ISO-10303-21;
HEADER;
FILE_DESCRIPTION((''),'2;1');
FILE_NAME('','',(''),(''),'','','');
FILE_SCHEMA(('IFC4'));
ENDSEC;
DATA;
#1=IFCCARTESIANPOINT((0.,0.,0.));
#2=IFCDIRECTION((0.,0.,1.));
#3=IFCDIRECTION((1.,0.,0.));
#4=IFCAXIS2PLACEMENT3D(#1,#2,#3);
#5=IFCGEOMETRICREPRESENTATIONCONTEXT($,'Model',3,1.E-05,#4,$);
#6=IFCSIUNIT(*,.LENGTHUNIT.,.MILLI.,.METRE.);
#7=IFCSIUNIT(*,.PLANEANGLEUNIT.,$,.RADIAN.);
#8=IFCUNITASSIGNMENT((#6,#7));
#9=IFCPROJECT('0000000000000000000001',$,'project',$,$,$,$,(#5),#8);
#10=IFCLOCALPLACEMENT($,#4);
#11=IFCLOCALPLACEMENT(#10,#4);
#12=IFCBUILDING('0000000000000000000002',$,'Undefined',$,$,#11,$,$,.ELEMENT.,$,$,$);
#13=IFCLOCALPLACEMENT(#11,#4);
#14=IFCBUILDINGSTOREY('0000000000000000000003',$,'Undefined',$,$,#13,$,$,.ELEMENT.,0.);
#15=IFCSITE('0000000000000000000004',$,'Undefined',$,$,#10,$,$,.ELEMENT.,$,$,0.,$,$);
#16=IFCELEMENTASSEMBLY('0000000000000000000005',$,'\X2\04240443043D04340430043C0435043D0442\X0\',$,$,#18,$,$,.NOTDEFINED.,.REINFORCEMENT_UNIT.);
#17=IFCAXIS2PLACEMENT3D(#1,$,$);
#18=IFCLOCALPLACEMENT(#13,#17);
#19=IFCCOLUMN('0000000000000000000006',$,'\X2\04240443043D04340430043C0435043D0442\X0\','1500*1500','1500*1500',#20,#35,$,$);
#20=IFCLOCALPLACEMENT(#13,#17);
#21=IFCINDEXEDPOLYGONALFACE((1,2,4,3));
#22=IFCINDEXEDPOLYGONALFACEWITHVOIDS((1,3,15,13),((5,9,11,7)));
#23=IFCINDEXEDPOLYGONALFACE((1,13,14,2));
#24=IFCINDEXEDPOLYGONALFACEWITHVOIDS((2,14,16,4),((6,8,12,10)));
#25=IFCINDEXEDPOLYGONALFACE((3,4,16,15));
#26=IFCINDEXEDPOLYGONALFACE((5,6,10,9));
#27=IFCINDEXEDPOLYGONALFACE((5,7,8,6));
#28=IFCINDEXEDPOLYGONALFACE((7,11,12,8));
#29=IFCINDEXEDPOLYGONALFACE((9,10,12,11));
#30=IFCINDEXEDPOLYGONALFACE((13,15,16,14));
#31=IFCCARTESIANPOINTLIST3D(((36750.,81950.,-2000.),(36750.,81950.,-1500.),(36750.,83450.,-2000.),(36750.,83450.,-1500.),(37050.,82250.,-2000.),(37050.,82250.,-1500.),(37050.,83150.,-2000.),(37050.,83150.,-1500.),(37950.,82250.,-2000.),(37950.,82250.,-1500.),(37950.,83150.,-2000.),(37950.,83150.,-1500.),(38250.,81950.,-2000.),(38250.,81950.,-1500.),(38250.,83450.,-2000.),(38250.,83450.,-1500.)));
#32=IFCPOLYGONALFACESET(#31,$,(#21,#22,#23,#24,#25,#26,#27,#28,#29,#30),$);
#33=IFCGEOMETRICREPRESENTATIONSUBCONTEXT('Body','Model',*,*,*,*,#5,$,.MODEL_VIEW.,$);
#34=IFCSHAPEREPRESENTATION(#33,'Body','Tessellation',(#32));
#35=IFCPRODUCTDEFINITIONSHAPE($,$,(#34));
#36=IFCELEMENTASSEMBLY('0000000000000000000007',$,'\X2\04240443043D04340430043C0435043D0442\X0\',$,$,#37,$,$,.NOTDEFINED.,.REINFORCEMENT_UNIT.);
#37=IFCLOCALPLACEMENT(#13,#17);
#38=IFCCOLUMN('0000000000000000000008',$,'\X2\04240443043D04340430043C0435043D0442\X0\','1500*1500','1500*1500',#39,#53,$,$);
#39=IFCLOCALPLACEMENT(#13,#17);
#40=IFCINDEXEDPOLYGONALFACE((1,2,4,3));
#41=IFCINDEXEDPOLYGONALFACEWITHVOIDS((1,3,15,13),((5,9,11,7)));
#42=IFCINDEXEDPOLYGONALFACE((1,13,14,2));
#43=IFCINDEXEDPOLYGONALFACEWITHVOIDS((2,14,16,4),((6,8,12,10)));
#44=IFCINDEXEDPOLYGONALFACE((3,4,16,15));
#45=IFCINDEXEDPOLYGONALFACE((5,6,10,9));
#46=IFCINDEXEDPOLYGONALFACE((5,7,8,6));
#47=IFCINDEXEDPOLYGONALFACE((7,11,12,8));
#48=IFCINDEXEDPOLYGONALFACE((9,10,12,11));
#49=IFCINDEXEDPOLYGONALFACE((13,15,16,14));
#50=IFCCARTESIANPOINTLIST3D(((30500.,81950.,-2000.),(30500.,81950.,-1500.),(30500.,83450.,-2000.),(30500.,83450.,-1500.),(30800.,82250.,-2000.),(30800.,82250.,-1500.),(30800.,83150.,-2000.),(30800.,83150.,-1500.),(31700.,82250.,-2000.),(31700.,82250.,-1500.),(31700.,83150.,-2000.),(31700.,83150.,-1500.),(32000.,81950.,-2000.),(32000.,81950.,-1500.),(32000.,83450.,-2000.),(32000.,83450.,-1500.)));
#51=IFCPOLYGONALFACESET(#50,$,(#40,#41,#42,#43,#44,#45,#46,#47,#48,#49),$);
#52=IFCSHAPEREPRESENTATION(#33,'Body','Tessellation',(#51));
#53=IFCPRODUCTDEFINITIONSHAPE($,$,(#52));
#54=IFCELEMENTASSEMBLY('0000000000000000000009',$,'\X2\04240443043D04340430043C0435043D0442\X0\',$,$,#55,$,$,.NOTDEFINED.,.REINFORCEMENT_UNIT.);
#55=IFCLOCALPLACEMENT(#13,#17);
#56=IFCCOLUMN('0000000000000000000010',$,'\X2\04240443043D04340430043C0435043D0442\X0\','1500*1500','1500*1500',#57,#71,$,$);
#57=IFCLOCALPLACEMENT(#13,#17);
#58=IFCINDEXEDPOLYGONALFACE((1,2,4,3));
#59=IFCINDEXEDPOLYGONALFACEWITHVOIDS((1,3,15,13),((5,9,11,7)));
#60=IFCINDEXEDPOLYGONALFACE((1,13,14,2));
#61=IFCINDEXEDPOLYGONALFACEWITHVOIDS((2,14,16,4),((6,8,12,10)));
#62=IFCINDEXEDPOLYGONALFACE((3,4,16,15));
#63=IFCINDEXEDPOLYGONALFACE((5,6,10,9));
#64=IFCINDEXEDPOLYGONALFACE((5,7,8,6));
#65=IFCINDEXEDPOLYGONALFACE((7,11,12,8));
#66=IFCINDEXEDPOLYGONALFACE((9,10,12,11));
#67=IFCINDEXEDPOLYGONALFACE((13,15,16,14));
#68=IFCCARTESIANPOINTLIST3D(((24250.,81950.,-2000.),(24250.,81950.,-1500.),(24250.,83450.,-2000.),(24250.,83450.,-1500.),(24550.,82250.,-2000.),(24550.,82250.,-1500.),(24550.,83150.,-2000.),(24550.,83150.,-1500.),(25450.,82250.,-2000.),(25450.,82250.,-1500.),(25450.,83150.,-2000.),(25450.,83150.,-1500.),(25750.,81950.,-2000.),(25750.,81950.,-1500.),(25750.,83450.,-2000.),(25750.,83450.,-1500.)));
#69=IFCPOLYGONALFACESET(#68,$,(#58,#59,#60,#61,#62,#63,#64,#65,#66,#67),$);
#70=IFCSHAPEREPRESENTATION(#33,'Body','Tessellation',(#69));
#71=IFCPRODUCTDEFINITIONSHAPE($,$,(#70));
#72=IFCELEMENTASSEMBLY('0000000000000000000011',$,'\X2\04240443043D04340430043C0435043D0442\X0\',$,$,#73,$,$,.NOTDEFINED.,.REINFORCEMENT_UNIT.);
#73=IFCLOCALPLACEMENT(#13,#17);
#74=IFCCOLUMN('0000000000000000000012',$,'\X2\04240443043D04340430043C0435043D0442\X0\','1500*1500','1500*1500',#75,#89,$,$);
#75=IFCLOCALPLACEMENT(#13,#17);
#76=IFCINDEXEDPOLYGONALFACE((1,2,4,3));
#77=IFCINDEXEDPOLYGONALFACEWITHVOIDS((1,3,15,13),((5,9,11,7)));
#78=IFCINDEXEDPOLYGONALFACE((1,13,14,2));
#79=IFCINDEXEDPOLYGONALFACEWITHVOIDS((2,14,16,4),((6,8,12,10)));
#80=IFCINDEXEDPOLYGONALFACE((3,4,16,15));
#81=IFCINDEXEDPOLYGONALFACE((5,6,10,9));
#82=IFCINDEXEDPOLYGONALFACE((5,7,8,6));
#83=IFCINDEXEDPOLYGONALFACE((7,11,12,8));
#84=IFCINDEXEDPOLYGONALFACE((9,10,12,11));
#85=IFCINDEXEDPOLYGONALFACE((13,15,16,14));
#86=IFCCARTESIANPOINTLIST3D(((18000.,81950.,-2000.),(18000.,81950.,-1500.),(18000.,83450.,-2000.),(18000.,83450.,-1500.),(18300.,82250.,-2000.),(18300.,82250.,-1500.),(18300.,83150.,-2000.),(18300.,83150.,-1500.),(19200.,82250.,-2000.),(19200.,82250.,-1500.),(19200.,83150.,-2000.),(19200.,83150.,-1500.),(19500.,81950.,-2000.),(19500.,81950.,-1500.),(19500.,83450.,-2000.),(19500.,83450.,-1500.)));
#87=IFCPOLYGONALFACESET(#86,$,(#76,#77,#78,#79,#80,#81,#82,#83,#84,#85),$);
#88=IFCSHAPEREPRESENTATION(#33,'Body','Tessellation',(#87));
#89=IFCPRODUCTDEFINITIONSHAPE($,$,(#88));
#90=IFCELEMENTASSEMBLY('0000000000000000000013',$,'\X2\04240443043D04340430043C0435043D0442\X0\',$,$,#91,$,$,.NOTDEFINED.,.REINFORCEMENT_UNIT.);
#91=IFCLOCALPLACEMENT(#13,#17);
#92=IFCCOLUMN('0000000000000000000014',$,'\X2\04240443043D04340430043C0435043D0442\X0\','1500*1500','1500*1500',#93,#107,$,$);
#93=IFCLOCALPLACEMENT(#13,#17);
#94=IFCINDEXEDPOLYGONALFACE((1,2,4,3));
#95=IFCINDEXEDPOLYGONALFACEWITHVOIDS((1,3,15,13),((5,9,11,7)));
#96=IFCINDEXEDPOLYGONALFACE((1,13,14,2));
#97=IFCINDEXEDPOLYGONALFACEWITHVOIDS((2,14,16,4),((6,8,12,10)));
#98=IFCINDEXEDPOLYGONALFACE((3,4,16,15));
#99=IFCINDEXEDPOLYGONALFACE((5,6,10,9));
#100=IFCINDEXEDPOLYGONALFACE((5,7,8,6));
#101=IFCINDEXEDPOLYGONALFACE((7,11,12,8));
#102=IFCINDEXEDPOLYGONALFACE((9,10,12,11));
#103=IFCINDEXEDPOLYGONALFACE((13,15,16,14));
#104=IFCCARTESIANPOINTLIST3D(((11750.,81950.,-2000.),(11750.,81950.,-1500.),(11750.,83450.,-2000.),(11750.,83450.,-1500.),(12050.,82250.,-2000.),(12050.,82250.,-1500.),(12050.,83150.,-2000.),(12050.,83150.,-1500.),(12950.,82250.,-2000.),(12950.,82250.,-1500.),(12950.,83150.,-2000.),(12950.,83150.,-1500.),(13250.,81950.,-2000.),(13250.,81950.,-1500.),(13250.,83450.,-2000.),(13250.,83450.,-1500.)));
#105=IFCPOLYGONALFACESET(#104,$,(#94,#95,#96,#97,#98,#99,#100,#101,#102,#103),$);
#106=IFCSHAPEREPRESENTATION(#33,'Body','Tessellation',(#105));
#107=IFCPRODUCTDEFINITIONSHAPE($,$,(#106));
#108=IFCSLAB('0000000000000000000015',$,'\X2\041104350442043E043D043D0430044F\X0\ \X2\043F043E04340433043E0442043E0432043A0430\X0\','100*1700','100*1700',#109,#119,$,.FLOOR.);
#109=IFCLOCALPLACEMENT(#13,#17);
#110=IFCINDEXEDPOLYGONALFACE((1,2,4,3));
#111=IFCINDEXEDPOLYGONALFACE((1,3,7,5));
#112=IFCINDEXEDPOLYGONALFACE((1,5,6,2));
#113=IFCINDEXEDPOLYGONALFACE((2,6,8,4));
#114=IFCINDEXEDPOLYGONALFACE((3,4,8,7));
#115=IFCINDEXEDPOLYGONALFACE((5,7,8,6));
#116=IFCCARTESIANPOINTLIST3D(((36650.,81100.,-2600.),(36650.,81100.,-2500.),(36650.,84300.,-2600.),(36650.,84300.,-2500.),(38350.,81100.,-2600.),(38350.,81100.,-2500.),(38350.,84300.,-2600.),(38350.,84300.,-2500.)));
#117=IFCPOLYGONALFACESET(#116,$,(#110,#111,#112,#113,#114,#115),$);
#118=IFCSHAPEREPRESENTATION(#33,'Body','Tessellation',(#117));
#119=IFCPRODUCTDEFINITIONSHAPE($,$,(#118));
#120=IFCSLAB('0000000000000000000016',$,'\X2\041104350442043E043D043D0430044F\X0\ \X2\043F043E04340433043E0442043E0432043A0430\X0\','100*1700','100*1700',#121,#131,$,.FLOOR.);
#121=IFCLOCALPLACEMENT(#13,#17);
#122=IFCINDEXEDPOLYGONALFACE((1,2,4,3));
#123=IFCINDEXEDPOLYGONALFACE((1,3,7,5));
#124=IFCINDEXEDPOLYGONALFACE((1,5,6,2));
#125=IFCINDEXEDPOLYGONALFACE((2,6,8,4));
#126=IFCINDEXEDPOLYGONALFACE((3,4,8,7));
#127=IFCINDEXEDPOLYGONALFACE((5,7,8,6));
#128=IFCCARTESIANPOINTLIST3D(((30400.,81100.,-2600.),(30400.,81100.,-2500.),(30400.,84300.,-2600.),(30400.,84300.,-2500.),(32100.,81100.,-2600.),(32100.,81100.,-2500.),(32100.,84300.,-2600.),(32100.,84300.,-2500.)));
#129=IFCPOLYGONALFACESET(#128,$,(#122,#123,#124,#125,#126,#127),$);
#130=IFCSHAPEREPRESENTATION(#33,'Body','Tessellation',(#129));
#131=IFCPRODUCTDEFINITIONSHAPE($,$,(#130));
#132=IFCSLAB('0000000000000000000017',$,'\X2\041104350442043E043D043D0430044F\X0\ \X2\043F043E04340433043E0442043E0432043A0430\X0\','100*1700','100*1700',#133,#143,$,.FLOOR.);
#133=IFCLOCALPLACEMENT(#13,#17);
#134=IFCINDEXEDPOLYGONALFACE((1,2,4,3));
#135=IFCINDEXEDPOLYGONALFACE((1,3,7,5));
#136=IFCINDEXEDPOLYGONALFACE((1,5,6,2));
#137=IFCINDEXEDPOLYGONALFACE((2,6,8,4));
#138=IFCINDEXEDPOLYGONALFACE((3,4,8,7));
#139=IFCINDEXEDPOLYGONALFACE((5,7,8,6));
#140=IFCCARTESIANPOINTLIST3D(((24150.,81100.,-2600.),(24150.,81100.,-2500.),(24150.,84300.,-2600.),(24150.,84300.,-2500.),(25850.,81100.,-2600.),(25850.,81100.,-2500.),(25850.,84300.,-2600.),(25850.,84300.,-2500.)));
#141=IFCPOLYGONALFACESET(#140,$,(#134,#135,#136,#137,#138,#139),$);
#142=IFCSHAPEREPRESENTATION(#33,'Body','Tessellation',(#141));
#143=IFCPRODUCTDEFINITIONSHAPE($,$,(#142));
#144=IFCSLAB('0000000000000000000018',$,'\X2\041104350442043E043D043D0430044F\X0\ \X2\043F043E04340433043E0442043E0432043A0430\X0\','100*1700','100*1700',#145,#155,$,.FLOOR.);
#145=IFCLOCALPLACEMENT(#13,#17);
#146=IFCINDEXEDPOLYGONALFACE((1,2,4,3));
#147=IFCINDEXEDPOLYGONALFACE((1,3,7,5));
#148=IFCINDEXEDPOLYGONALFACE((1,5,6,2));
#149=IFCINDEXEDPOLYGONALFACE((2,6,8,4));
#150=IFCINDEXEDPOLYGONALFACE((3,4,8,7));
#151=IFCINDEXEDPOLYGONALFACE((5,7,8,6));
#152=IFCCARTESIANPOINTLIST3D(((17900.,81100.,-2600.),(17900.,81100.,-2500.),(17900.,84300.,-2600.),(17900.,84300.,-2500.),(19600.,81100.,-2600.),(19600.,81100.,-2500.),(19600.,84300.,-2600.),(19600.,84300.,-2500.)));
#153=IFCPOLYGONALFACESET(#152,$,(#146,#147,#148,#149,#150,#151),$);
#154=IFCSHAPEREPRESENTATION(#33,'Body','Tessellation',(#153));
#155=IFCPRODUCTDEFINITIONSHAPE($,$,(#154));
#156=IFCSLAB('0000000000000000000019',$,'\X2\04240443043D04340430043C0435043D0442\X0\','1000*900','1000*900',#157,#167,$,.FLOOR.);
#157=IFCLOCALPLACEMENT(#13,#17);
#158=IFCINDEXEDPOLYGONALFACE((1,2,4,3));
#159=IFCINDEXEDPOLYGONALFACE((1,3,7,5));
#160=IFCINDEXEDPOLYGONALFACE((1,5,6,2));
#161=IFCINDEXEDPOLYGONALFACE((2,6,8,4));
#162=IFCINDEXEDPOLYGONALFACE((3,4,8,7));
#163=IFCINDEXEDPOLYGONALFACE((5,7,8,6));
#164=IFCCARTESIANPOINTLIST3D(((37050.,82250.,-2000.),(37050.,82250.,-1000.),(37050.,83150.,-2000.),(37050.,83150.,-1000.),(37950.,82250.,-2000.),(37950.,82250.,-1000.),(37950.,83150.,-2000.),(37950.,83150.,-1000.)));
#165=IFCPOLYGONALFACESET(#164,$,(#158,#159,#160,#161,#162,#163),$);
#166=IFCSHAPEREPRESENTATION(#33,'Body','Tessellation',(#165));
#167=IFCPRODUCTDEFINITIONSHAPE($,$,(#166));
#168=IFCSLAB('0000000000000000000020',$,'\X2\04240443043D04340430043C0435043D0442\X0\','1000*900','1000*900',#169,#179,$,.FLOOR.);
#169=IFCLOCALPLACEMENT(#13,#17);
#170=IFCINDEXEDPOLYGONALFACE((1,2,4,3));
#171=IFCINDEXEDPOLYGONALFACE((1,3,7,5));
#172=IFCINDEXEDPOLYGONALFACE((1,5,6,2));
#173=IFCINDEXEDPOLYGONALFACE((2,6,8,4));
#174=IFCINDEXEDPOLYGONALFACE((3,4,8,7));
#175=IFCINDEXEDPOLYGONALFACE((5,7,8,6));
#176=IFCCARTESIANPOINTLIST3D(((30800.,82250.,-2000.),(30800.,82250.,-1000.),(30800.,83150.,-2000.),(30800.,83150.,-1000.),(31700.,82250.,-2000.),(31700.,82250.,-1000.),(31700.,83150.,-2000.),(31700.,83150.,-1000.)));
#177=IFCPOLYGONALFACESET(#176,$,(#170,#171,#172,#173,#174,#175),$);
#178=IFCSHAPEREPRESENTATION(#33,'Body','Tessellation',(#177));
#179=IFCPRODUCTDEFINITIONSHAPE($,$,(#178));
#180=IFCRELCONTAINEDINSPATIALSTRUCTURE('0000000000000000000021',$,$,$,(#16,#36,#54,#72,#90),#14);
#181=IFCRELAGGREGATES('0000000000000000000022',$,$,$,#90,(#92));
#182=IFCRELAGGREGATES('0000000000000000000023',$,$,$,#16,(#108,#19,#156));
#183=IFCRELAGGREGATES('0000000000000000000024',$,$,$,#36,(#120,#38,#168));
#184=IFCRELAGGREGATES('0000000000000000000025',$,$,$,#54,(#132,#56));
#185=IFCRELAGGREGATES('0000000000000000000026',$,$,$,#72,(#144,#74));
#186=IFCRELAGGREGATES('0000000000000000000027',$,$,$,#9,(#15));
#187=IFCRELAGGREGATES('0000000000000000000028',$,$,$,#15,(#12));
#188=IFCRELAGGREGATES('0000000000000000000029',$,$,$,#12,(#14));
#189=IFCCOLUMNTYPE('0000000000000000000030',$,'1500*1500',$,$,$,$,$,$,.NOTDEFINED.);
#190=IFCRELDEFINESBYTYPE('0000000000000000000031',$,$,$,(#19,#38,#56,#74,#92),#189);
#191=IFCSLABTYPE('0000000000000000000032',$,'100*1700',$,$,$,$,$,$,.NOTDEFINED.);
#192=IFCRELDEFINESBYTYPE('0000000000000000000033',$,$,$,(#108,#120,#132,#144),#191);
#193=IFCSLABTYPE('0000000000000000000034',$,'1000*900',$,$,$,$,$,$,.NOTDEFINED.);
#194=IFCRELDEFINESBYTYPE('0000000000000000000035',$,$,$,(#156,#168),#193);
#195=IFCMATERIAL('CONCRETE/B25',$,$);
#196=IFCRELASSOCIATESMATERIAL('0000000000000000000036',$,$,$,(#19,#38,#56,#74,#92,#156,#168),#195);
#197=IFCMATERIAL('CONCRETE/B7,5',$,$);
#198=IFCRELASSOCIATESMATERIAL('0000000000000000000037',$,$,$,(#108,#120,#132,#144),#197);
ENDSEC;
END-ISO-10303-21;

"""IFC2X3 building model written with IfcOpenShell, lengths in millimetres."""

from ifc_helpers import new_model, si_unit, frame, origin_with_axes, origin_2d_with_axis, place, context, subcontext, project, spatial, polyline, rectangle, outline, extrude, boolean, material, type_object, element, aggregate, save


model = new_model("IFC2X3")

# Units and contexts
model_context = context("Model", 3, precision=1e-05, world=origin_with_axes())
body_context = subcontext(model_context, "Body", "Model", "MODEL_VIEW")
ifc_project = project(units=[si_unit("LENGTHUNIT", "METRE", prefix="MILLI"), si_unit("PLANEANGLEUNIT", "RADIAN")], contexts=[model_context])

# Site, building, storey
site_placement = place(None, origin_with_axes())
site = spatial("IfcSite", under=ifc_project, at=site_placement, Name="Undefined", CompositionType="ELEMENT", RefElevation=0.0)
building_placement = place(site_placement, origin_with_axes())
building = spatial("IfcBuilding", under=site, at=building_placement, Name="Undefined", CompositionType="ELEMENT")
storey_placement = place(building_placement, origin_with_axes())
storey = spatial("IfcBuildingStorey", under=building, at=storey_placement, Name="Undefined", CompositionType="ELEMENT", Elevation=0.0)

# Element assemblies, columns
assembly_1_placement = place(storey_placement, origin_with_axes())
assembly_1 = element("IfcElementAssembly", 1, at=assembly_1_placement, inside=storey, Name="Фундамент", AssemblyPlace="NOTDEFINED", PredefinedType="REINFORCEMENT_UNIT")
ifc_material_1 = material(Name="CONCRETE/B25")
column_type = type_object("IfcColumnType", Name="1500*1500", PredefinedType="NOTDEFINED")
column_1_placement = place(assembly_1_placement, frame((37500.0, 82700.0, -2000.0), z_axis=(0.0, 0.0, 1.0), x_axis=(0.0, -1.0, 0.0)))
column_1 = element("IfcColumn", 2, at=column_1_placement, type_object=column_type, material=ifc_material_1, Name="Фундамент", Description="1500*1500", ObjectType="1500*1500", context=body_context, shape_type="CSG", body=[
    boolean("DIFFERENCE", extrude(rectangle(XDim=1500.0, YDim=1500.0, at=origin_2d_with_axis()), frame((0.0, 0.0, 500.0), z_axis=(0.0, 0.0, -1.0), x_axis=(0.0, 1.0, 0.0)), (0.0, 0.0, 1.0), 500.0), extrude(outline(polyline([(0.0, 0.0), (900.0, 0.0), (900.0, 900.0), (0.0, 900.0), (0.0, 0.0)])), frame((-450.0, -450.0, -100.0), z_axis=(0.0, 0.0, 1.0), x_axis=(1.0, 0.0, 0.0)), (0.0, 0.0, 1.0), 700.0)),
])
assembly_2_placement = place(storey_placement, origin_with_axes())
assembly_2 = element("IfcElementAssembly", 3, at=assembly_2_placement, inside=storey, Name="Фундамент", AssemblyPlace="NOTDEFINED", PredefinedType="REINFORCEMENT_UNIT")
column_2_placement = place(assembly_2_placement, frame((31250.0, 82700.0, -2000.0), z_axis=(0.0, 0.0, 1.0), x_axis=(0.0, -1.0, 0.0)))
column_2 = element("IfcColumn", 4, at=column_2_placement, type_object=column_type, material=ifc_material_1, Name="Фундамент", Description="1500*1500", ObjectType="1500*1500", context=body_context, shape_type="CSG", body=[
    boolean("DIFFERENCE", extrude(rectangle(XDim=1500.0, YDim=1500.0, at=origin_2d_with_axis()), frame((0.0, 0.0, 500.0), z_axis=(0.0, 0.0, -1.0), x_axis=(0.0, 1.0, 0.0)), (0.0, 0.0, 1.0), 500.0), extrude(outline(polyline([(0.0, 0.0), (900.0, 0.0), (900.0, 900.0), (0.0, 900.0), (0.0, 0.0)])), frame((-450.0, -450.0, -100.0), z_axis=(0.0, 0.0, 1.0), x_axis=(1.0, 0.0, 0.0)), (0.0, 0.0, 1.0), 700.0)),
])
assembly_3_placement = place(storey_placement, origin_with_axes())
assembly_3 = element("IfcElementAssembly", 5, at=assembly_3_placement, inside=storey, Name="Фундамент", AssemblyPlace="NOTDEFINED", PredefinedType="REINFORCEMENT_UNIT")
column_3_placement = place(assembly_3_placement, frame((25000.0, 82700.0, -2000.0), z_axis=(0.0, 0.0, 1.0), x_axis=(0.0, -1.0, 0.0)))
column_3 = element("IfcColumn", 6, at=column_3_placement, type_object=column_type, material=ifc_material_1, Name="Фундамент", Description="1500*1500", ObjectType="1500*1500", context=body_context, shape_type="CSG", body=[
    boolean("DIFFERENCE", extrude(rectangle(XDim=1500.0, YDim=1500.0, at=origin_2d_with_axis()), frame((0.0, 0.0, 500.0), z_axis=(0.0, 0.0, -1.0), x_axis=(0.0, 1.0, 0.0)), (0.0, 0.0, 1.0), 500.0), extrude(outline(polyline([(0.0, 0.0), (900.0, 0.0), (900.0, 900.0), (0.0, 900.0), (0.0, 0.0)])), frame((-450.0, -450.0, -100.0), z_axis=(0.0, 0.0, 1.0), x_axis=(1.0, 0.0, 0.0)), (0.0, 0.0, 1.0), 700.0)),
])
assembly_4_placement = place(storey_placement, origin_with_axes())
assembly_4 = element("IfcElementAssembly", 7, at=assembly_4_placement, inside=storey, Name="Фундамент", AssemblyPlace="NOTDEFINED", PredefinedType="REINFORCEMENT_UNIT")
column_4_placement = place(assembly_4_placement, frame((18750.0, 82700.0, -2000.0), z_axis=(0.0, 0.0, 1.0), x_axis=(0.0, -1.0, 0.0)))
column_4 = element("IfcColumn", 8, at=column_4_placement, type_object=column_type, material=ifc_material_1, Name="Фундамент", Description="1500*1500", ObjectType="1500*1500", context=body_context, shape_type="CSG", body=[
    boolean("DIFFERENCE", extrude(rectangle(XDim=1500.0, YDim=1500.0, at=origin_2d_with_axis()), frame((0.0, 0.0, 500.0), z_axis=(0.0, 0.0, -1.0), x_axis=(0.0, 1.0, 0.0)), (0.0, 0.0, 1.0), 500.0), extrude(outline(polyline([(0.0, 0.0), (900.0, 0.0), (900.0, 900.0), (0.0, 900.0), (0.0, 0.0)])), frame((-450.0, -450.0, -100.0), z_axis=(0.0, 0.0, 1.0), x_axis=(1.0, 0.0, 0.0)), (0.0, 0.0, 1.0), 700.0)),
])
assembly_5_placement = place(storey_placement, origin_with_axes())
assembly_5 = element("IfcElementAssembly", 9, at=assembly_5_placement, inside=storey, Name="Фундамент", AssemblyPlace="NOTDEFINED", PredefinedType="REINFORCEMENT_UNIT")
column_5_placement = place(assembly_5_placement, frame((12500.0, 82700.0, -2000.0), z_axis=(0.0, 0.0, 1.0), x_axis=(0.0, -1.0, 0.0)))
column_5 = element("IfcColumn", 10, at=column_5_placement, type_object=column_type, material=ifc_material_1, Name="Фундамент", Description="1500*1500", ObjectType="1500*1500", context=body_context, shape_type="CSG", body=[
    boolean("DIFFERENCE", extrude(rectangle(XDim=1500.0, YDim=1500.0, at=origin_2d_with_axis()), frame((0.0, 0.0, 500.0), z_axis=(0.0, 0.0, -1.0), x_axis=(0.0, 1.0, 0.0)), (0.0, 0.0, 1.0), 500.0), extrude(outline(polyline([(0.0, 0.0), (900.0, 0.0), (900.0, 900.0), (0.0, 900.0), (0.0, 0.0)])), frame((-450.0, -450.0, -100.0), z_axis=(0.0, 0.0, 1.0), x_axis=(1.0, 0.0, 0.0)), (0.0, 0.0, 1.0), 700.0)),
])

# Slabs
ifc_material_2 = material(Name="CONCRETE/B7,5")
slab_type_1 = type_object("IfcSlabType", Name="100*1700", PredefinedType="NOTDEFINED")
slab_1_placement = place(assembly_1_placement, frame((36650.0, 84300.0, -2550.0), z_axis=(0.0, 0.0, 1.0), x_axis=(0.0, -1.0, 0.0)))
slab_1 = element("IfcSlab", 11, at=slab_1_placement, type_object=slab_type_1, material=ifc_material_2, Name="Бетонная подготовка", Description="100*1700", ObjectType="100*1700", PredefinedType="FLOOR", context=body_context, shape_type="SweptSolid", body=[
    extrude(outline(polyline([(0.0, 0.0), (3200.0, 0.0), (3200.0, 1700.0), (0.0, 1700.0), (0.0, 0.0)])), frame((0.0, 0.0, -50.0), z_axis=(0.0, 0.0, 1.0), x_axis=(1.0, 0.0, 0.0)), (0.0, 0.0, 1.0), 100.0),
])
slab_2_placement = place(assembly_2_placement, frame((30400.0, 84300.0, -2550.0), z_axis=(0.0, 0.0, 1.0), x_axis=(0.0, -1.0, 0.0)))
slab_2 = element("IfcSlab", 12, at=slab_2_placement, type_object=slab_type_1, material=ifc_material_2, Name="Бетонная подготовка", Description="100*1700", ObjectType="100*1700", PredefinedType="FLOOR", context=body_context, shape_type="SweptSolid", body=[
    extrude(outline(polyline([(0.0, 0.0), (3200.0, 0.0), (3200.0, 1700.0), (0.0, 1700.0), (0.0, 0.0)])), frame((0.0, 0.0, -50.0), z_axis=(0.0, 0.0, 1.0), x_axis=(1.0, 0.0, 0.0)), (0.0, 0.0, 1.0), 100.0),
])
slab_3_placement = place(assembly_3_placement, frame((24150.0, 84300.0, -2550.0), z_axis=(0.0, 0.0, 1.0), x_axis=(0.0, -1.0, 0.0)))
slab_3 = element("IfcSlab", 13, at=slab_3_placement, type_object=slab_type_1, material=ifc_material_2, Name="Бетонная подготовка", Description="100*1700", ObjectType="100*1700", PredefinedType="FLOOR", context=body_context, shape_type="SweptSolid", body=[
    extrude(outline(polyline([(0.0, 0.0), (3200.0, 0.0), (3200.0, 1700.0), (0.0, 1700.0), (0.0, 0.0)])), frame((0.0, 0.0, -50.0), z_axis=(0.0, 0.0, 1.0), x_axis=(1.0, 0.0, 0.0)), (0.0, 0.0, 1.0), 100.0),
])
slab_4_placement = place(assembly_4_placement, frame((17900.0, 84300.0, -2550.0), z_axis=(0.0, 0.0, 1.0), x_axis=(0.0, -1.0, 0.0)))
slab_4 = element("IfcSlab", 14, at=slab_4_placement, type_object=slab_type_1, material=ifc_material_2, Name="Бетонная подготовка", Description="100*1700", ObjectType="100*1700", PredefinedType="FLOOR", context=body_context, shape_type="SweptSolid", body=[
    extrude(outline(polyline([(0.0, 0.0), (3200.0, 0.0), (3200.0, 1700.0), (0.0, 1700.0), (0.0, 0.0)])), frame((0.0, 0.0, -50.0), z_axis=(0.0, 0.0, 1.0), x_axis=(1.0, 0.0, 0.0)), (0.0, 0.0, 1.0), 100.0),
])
slab_type_2 = type_object("IfcSlabType", Name="1000*900", PredefinedType="NOTDEFINED")
slab_5_placement = place(assembly_1_placement, frame((37050.0, 83150.0, -1500.0), z_axis=(0.0, 0.0, 1.0), x_axis=(0.0, -1.0, 0.0)))
slab_5 = element("IfcSlab", 15, at=slab_5_placement, type_object=slab_type_2, material=ifc_material_1, Name="Фундамент", Description="1000*900", ObjectType="1000*900", PredefinedType="FLOOR", context=body_context, shape_type="SweptSolid", body=[
    extrude(outline(polyline([(0.0, 0.0), (900.0, 0.0), (900.0, 900.0), (0.0, 900.0), (0.0, 0.0)])), frame((0.0, 0.0, -500.0), z_axis=(0.0, 0.0, 1.0), x_axis=(1.0, 0.0, 0.0)), (0.0, 0.0, 1.0), 1000.0),
])
slab_6_placement = place(assembly_2_placement, frame((30800.0, 83150.0, -1500.0), z_axis=(0.0, 0.0, 1.0), x_axis=(0.0, -1.0, 0.0)))
slab_6 = element("IfcSlab", 16, at=slab_6_placement, type_object=slab_type_2, material=ifc_material_1, Name="Фундамент", Description="1000*900", ObjectType="1000*900", PredefinedType="FLOOR", context=body_context, shape_type="SweptSolid", body=[
    extrude(outline(polyline([(0.0, 0.0), (900.0, 0.0), (900.0, 900.0), (0.0, 900.0), (0.0, 0.0)])), frame((0.0, 0.0, -500.0), z_axis=(0.0, 0.0, 1.0), x_axis=(1.0, 0.0, 0.0)), (0.0, 0.0, 1.0), 1000.0),
])
aggregate(assembly_5, [column_5])
aggregate(assembly_1, [slab_1, column_1, slab_5])
aggregate(assembly_2, [slab_2, column_2, slab_6])
aggregate(assembly_3, [slab_3, column_3])
aggregate(assembly_4, [slab_4, column_4])

save(model, "model.ifc")
